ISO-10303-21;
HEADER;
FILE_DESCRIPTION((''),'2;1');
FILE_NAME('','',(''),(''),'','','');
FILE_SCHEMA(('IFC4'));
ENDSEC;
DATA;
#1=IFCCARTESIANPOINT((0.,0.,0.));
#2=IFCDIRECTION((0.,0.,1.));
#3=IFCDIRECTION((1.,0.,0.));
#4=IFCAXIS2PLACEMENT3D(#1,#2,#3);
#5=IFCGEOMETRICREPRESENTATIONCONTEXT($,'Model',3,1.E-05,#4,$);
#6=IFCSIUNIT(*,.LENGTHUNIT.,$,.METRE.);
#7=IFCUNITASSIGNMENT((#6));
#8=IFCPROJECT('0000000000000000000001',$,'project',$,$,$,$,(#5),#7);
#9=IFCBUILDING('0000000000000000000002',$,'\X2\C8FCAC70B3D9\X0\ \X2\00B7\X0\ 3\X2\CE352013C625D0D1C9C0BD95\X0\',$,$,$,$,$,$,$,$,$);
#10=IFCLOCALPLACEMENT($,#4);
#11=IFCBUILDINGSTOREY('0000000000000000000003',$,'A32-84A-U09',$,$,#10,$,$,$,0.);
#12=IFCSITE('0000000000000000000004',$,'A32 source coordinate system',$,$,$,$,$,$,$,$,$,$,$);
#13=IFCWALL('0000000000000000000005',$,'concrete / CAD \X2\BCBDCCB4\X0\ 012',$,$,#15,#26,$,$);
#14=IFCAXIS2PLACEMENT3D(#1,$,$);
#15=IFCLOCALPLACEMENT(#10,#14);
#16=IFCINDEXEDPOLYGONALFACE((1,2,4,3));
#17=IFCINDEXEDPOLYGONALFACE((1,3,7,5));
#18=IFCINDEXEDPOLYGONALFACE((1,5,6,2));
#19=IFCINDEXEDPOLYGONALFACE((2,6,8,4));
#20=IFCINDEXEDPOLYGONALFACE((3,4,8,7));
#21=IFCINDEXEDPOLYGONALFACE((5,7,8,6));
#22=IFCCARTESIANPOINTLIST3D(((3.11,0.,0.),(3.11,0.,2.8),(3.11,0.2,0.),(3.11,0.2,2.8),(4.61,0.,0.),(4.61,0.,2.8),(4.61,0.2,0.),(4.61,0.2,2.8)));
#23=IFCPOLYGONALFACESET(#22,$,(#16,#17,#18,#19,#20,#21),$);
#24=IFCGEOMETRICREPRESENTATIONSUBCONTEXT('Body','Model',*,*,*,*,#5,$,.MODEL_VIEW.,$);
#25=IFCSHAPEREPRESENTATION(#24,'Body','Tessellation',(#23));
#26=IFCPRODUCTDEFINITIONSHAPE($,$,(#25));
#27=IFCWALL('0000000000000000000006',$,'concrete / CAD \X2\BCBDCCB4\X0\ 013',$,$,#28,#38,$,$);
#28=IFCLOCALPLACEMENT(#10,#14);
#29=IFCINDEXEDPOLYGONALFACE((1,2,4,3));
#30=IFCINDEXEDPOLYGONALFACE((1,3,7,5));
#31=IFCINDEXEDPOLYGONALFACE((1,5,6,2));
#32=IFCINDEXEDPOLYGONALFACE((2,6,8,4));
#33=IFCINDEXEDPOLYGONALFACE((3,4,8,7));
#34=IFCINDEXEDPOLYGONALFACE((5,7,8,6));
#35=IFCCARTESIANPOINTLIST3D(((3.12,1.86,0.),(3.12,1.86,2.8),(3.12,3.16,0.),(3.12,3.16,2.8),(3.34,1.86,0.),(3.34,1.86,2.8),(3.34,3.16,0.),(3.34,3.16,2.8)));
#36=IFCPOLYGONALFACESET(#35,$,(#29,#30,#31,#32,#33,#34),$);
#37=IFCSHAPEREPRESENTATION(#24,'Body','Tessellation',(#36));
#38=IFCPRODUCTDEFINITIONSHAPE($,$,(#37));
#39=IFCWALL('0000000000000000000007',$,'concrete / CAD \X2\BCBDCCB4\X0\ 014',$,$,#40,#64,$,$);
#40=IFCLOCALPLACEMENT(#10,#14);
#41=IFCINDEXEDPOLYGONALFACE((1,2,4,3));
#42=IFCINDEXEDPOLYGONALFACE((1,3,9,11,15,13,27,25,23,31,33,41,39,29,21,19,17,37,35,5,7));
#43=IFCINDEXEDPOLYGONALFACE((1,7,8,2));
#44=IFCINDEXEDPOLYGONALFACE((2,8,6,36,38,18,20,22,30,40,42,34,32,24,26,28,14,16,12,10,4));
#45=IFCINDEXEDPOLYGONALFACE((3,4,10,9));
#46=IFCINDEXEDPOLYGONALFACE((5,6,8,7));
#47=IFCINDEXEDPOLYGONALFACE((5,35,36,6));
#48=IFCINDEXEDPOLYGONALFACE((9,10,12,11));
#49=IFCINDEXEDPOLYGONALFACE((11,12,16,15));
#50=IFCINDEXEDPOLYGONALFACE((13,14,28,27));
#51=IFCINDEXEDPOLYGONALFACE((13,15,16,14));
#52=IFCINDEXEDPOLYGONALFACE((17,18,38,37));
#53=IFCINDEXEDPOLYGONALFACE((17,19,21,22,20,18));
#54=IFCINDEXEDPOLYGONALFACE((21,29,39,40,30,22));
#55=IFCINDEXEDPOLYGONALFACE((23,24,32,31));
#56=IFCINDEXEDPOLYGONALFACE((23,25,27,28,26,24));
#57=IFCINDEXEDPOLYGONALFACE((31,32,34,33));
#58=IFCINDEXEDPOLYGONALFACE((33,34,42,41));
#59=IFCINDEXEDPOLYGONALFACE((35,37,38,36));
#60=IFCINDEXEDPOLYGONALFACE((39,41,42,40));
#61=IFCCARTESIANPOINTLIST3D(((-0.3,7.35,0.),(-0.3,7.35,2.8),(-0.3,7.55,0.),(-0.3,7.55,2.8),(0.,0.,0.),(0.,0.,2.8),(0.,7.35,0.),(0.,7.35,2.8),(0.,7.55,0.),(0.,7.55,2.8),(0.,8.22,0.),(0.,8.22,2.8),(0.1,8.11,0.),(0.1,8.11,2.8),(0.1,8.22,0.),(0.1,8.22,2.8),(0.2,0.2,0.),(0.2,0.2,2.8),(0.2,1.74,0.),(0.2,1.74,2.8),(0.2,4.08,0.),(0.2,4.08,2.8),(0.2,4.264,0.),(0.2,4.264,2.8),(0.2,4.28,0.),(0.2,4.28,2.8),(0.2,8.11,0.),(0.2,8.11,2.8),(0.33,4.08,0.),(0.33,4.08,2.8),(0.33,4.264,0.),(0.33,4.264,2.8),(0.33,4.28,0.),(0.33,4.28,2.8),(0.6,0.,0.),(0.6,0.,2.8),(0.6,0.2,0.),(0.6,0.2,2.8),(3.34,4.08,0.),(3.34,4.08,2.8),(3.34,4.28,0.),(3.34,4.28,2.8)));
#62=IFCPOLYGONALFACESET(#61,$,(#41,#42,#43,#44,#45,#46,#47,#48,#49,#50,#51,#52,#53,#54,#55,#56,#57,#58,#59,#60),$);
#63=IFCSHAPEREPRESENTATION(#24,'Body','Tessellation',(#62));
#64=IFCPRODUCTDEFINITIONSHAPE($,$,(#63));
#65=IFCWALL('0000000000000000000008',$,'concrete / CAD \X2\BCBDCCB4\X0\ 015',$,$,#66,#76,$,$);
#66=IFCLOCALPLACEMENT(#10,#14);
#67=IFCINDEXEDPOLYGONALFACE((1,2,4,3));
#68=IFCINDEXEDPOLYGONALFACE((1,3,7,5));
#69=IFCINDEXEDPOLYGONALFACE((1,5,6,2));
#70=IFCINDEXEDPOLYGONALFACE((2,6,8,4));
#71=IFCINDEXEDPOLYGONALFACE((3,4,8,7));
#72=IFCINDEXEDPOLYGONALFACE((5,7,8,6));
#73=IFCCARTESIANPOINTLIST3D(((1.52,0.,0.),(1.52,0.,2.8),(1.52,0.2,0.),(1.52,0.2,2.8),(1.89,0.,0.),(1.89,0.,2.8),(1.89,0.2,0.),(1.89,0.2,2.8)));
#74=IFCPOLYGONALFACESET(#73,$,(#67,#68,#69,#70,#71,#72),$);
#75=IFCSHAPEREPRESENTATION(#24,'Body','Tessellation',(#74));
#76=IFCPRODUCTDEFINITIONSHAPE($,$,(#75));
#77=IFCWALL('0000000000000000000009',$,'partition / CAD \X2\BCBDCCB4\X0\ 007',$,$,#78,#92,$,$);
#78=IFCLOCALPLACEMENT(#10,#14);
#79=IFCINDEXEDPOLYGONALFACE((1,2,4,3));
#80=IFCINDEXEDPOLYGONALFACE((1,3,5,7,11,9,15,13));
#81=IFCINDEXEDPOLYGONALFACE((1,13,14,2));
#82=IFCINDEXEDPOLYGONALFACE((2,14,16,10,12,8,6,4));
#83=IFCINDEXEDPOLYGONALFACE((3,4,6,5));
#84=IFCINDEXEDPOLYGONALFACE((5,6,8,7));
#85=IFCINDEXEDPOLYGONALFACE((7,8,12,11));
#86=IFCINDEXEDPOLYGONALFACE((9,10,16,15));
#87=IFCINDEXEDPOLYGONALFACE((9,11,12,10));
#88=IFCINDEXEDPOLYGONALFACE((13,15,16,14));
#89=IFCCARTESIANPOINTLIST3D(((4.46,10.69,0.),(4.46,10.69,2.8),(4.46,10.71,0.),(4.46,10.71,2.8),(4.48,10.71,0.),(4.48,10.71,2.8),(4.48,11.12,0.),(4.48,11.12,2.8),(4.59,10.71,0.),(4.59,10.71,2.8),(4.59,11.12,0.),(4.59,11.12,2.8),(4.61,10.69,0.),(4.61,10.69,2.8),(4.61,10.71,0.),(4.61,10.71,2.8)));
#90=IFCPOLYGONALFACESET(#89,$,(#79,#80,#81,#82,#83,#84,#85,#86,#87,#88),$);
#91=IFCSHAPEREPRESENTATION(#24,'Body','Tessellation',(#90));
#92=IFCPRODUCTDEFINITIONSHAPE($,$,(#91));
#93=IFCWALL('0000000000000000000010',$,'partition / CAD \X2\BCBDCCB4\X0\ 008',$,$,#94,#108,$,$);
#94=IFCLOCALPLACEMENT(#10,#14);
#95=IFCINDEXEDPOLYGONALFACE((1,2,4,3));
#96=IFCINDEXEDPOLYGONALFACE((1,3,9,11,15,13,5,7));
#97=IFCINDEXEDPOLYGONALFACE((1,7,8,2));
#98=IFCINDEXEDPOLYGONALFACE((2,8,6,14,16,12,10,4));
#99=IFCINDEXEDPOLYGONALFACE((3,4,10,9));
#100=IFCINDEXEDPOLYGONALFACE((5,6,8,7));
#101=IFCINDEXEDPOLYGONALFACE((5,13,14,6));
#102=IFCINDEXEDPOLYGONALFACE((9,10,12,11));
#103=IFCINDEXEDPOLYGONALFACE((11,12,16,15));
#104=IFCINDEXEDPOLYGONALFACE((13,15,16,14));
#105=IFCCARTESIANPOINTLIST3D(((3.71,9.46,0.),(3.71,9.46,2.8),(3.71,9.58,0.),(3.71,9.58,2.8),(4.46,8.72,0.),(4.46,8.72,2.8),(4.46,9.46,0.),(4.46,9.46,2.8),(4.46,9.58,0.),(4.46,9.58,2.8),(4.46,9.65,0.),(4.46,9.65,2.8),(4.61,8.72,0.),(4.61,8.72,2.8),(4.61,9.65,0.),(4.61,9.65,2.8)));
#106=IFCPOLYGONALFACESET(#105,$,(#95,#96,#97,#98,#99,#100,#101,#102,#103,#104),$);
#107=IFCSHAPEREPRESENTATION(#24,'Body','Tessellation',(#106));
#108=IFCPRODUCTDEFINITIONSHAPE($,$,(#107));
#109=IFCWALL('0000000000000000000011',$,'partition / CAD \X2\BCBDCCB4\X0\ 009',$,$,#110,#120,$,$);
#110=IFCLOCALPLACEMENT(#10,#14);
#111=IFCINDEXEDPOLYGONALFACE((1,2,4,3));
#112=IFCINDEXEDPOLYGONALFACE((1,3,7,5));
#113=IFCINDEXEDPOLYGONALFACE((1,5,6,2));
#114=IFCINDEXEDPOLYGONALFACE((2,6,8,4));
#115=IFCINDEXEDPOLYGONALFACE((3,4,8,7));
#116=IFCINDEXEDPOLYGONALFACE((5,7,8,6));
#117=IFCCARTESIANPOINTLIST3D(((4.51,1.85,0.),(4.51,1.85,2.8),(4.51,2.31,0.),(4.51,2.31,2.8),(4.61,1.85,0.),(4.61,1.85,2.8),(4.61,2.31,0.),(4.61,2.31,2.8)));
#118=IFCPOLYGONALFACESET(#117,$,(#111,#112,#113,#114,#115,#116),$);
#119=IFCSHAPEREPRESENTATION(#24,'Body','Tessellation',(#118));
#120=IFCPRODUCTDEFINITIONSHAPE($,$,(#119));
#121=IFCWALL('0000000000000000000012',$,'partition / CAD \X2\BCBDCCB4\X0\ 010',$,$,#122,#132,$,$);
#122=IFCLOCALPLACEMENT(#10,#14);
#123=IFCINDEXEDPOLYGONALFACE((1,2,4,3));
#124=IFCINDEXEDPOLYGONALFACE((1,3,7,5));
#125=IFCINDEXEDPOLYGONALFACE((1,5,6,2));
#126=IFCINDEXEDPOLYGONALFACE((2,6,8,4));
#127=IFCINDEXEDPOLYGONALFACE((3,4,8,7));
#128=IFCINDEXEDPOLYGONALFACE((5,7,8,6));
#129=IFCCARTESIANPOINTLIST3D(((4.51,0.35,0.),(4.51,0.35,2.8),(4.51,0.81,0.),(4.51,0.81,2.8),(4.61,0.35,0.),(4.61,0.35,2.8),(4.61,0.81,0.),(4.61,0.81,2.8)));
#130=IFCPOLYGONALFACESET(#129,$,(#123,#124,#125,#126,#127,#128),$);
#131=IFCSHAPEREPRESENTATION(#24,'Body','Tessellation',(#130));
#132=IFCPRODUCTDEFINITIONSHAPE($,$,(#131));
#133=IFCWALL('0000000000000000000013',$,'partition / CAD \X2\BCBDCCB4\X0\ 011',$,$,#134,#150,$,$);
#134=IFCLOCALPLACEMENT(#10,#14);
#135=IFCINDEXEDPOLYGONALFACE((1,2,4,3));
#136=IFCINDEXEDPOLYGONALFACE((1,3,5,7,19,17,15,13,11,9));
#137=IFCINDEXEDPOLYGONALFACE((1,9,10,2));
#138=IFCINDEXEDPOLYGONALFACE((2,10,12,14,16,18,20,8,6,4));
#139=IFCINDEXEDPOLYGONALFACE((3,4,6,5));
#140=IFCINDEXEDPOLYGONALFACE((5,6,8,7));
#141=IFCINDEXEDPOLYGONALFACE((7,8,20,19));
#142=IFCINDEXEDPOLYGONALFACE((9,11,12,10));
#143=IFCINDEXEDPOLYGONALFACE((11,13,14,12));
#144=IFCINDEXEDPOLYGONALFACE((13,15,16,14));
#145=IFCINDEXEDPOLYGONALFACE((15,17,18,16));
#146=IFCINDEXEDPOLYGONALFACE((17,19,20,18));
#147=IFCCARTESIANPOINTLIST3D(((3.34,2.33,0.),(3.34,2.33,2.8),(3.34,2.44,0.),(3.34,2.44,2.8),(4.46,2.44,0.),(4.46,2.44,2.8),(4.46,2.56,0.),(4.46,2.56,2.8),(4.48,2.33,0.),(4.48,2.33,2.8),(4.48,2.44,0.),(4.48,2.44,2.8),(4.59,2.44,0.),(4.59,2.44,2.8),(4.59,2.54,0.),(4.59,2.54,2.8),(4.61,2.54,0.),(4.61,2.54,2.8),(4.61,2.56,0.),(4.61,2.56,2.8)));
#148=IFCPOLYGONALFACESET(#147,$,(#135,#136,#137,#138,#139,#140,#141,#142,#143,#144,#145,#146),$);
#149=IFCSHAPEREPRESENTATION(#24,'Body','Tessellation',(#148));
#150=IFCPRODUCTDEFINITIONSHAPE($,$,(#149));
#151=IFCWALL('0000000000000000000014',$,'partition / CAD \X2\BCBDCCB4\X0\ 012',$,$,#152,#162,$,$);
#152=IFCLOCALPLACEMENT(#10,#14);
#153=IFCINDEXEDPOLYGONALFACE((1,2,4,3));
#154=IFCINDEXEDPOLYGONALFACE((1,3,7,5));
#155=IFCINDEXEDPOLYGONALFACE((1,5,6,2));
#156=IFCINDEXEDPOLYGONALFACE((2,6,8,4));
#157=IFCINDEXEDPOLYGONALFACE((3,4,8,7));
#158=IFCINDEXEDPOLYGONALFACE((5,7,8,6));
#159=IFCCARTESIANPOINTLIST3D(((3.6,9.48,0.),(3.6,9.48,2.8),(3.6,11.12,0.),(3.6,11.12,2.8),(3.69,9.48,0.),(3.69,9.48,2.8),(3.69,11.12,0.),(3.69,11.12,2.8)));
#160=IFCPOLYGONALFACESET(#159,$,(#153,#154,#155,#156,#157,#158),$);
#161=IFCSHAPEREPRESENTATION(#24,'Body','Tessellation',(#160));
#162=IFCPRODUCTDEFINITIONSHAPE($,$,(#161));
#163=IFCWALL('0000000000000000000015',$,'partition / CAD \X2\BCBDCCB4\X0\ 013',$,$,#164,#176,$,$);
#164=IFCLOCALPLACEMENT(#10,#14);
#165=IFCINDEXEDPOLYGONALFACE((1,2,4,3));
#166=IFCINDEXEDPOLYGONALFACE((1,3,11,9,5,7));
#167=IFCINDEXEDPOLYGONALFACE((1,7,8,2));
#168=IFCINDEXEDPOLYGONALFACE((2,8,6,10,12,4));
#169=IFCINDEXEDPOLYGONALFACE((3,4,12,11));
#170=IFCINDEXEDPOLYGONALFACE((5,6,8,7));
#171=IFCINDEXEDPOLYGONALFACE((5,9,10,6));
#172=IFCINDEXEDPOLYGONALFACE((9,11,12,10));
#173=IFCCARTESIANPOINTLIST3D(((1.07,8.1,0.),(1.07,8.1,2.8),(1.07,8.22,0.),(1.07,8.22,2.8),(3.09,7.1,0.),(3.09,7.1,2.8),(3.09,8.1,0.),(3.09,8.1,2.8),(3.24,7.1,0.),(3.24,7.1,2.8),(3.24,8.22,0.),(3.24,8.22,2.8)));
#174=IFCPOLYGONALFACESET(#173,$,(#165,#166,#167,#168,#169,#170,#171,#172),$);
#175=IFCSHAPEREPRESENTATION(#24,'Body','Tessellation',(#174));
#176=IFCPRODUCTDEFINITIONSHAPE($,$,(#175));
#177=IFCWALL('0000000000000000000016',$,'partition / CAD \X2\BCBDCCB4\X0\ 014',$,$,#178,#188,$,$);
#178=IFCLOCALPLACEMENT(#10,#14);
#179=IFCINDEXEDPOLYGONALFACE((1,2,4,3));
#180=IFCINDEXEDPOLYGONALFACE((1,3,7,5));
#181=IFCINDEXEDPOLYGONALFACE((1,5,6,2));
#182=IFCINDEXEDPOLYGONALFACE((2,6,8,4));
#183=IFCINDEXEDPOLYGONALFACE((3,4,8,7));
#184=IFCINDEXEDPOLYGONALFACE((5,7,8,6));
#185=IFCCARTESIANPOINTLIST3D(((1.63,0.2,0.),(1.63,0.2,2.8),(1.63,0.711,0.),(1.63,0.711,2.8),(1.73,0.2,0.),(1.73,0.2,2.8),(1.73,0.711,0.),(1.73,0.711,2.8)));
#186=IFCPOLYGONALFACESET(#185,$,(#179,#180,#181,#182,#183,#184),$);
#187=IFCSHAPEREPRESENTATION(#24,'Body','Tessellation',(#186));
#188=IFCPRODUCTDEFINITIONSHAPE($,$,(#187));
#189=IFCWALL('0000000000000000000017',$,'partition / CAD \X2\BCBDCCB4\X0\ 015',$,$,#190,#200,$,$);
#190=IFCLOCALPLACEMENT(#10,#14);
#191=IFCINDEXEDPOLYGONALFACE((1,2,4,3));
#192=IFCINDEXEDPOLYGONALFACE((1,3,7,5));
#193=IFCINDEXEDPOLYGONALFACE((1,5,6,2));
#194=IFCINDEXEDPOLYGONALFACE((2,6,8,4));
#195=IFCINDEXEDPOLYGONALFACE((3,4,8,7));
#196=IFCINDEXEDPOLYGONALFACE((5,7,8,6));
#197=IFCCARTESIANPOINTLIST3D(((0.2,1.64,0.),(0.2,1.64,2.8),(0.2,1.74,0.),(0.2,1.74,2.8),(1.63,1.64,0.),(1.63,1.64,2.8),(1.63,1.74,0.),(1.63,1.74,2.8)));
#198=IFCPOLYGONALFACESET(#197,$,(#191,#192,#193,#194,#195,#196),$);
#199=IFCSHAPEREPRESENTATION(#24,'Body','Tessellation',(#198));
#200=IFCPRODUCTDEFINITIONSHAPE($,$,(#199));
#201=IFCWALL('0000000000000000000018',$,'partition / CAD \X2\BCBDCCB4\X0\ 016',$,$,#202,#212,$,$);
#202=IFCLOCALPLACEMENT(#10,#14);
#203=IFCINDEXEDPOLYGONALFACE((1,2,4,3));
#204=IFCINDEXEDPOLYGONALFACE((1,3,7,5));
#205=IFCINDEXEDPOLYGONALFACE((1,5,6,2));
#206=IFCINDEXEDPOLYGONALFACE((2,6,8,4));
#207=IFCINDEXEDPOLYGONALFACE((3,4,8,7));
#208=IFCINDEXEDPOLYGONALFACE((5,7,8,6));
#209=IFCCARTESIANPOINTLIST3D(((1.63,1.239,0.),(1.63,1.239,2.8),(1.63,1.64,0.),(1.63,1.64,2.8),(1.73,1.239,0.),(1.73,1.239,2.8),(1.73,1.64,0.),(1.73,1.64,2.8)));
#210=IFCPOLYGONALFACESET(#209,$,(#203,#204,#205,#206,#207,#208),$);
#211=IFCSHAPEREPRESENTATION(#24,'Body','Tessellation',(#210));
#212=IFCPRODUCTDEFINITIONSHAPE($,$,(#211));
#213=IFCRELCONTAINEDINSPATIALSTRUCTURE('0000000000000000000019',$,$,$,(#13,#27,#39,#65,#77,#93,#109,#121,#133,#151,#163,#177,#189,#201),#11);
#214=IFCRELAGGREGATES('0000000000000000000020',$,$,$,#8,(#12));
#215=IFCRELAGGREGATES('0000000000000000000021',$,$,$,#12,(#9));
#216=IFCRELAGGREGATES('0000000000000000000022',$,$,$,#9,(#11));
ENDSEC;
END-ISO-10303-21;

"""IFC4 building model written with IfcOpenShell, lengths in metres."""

from ifc_helpers import new_model, si_unit, origin, origin_with_axes, place, context, subcontext, project, spatial, polyline, outline, extrude, element, save


model = new_model("IFC4")

# Units and contexts
model_context = context("Model", 3, precision=1e-05, world=origin_with_axes())
body_context = subcontext(model_context, "Body", "Model", "MODEL_VIEW")
ifc_project = project(units=[si_unit("LENGTHUNIT", "METRE")], contexts=[model_context])

# Site, building, storey
site = spatial("IfcSite", under=ifc_project, Name="A32 source coordinate system")
building = spatial("IfcBuilding", under=site, Name="주거동 · 3층–옥탑지붕")
storey_placement = place(None, origin_with_axes())
storey = spatial("IfcBuildingStorey", under=building, at=storey_placement, Name="A32-84A-U09", Elevation=0.0)

# Walls
wall_1_placement = place(storey_placement, origin_with_axes())
element("IfcWall", 1, at=wall_1_placement, inside=storey, Name="concrete / CAD 벽체 012", context=body_context, shape_type="SweptSolid", body=[
    extrude(outline(polyline([(3.11, 0.0), (3.11, 0.2), (4.61, 0.2), (4.61, 0.0), (3.11, 0.0)])), origin(), (0.0, 0.0, 1.0), 2.8),
])
wall_2_placement = place(storey_placement, origin_with_axes())
element("IfcWall", 2, at=wall_2_placement, inside=storey, Name="concrete / CAD 벽체 013", context=body_context, shape_type="SweptSolid", body=[
    extrude(outline(polyline([(3.12, 3.16), (3.34, 3.16), (3.34, 1.86), (3.12, 1.86), (3.12, 3.16)])), origin(), (0.0, 0.0, 1.0), 2.8),
])
wall_3_placement = place(storey_placement, origin_with_axes())
element("IfcWall", 3, at=wall_3_placement, inside=storey, Name="concrete / CAD 벽체 014", context=body_context, shape_type="SweptSolid", body=[
    extrude(outline(polyline([(3.34, 4.08), (0.33, 4.08), (0.2, 4.08), (0.2, 1.74), (0.2, 0.2), (0.6, 0.2), (0.6, 0.0), (0.0, 0.0), (0.0, 7.35), (-0.3, 7.35), (-0.3, 7.55), (0.0, 7.55), (0.0, 8.22), (0.1, 8.22), (0.1, 8.11), (0.2, 8.11), (0.2, 4.28), (0.2, 4.264), (0.33, 4.264), (0.33, 4.28), (3.34, 4.28), (3.34, 4.08)])), origin(), (0.0, 0.0, 1.0), 2.8),
])
wall_4_placement = place(storey_placement, origin_with_axes())
element("IfcWall", 4, at=wall_4_placement, inside=storey, Name="concrete / CAD 벽체 015", context=body_context, shape_type="SweptSolid", body=[
    extrude(outline(polyline([(1.52, 0.2), (1.89, 0.2), (1.89, 0.0), (1.52, 0.0), (1.52, 0.2)])), origin(), (0.0, 0.0, 1.0), 2.8),
])
wall_5_placement = place(storey_placement, origin_with_axes())
element("IfcWall", 5, at=wall_5_placement, inside=storey, Name="partition / CAD 벽체 007", context=body_context, shape_type="SweptSolid", body=[
    extrude(outline(polyline([(4.46, 10.71), (4.48, 10.71), (4.48, 11.12), (4.59, 11.12), (4.59, 10.71), (4.61, 10.71), (4.61, 10.69), (4.46, 10.69), (4.46, 10.71)])), origin(), (0.0, 0.0, 1.0), 2.8),
])
wall_6_placement = place(storey_placement, origin_with_axes())
element("IfcWall", 6, at=wall_6_placement, inside=storey, Name="partition / CAD 벽체 008", context=body_context, shape_type="SweptSolid", body=[
    extrude(outline(polyline([(4.61, 8.72), (4.46, 8.72), (4.46, 9.46), (3.71, 9.46), (3.71, 9.58), (4.46, 9.58), (4.46, 9.65), (4.61, 9.65), (4.61, 8.72)])), origin(), (0.0, 0.0, 1.0), 2.8),
])
wall_7_placement = place(storey_placement, origin_with_axes())
element("IfcWall", 7, at=wall_7_placement, inside=storey, Name="partition / CAD 벽체 009", context=body_context, shape_type="SweptSolid", body=[
    extrude(outline(polyline([(4.51, 1.85), (4.51, 2.31), (4.61, 2.31), (4.61, 1.85), (4.51, 1.85)])), origin(), (0.0, 0.0, 1.0), 2.8),
])
wall_8_placement = place(storey_placement, origin_with_axes())
element("IfcWall", 8, at=wall_8_placement, inside=storey, Name="partition / CAD 벽체 010", context=body_context, shape_type="SweptSolid", body=[
    extrude(outline(polyline([(4.51, 0.81), (4.61, 0.81), (4.61, 0.35), (4.51, 0.35), (4.51, 0.81)])), origin(), (0.0, 0.0, 1.0), 2.8),
])
wall_9_placement = place(storey_placement, origin_with_axes())
element("IfcWall", 9, at=wall_9_placement, inside=storey, Name="partition / CAD 벽체 011", context=body_context, shape_type="SweptSolid", body=[
    extrude(outline(polyline([(3.34, 2.33), (3.34, 2.44), (4.46, 2.44), (4.46, 2.56), (4.61, 2.56), (4.61, 2.54), (4.59, 2.54), (4.59, 2.44), (4.48, 2.44), (4.48, 2.33), (3.34, 2.33)])), origin(), (0.0, 0.0, 1.0), 2.8),
])
wall_10_placement = place(storey_placement, origin_with_axes())
element("IfcWall", 10, at=wall_10_placement, inside=storey, Name="partition / CAD 벽체 012", context=body_context, shape_type="SweptSolid", body=[
    extrude(outline(polyline([(3.6, 11.12), (3.69, 11.12), (3.69, 9.48), (3.6, 9.48), (3.6, 11.12)])), origin(), (0.0, 0.0, 1.0), 2.8),
])
wall_11_placement = place(storey_placement, origin_with_axes())
element("IfcWall", 11, at=wall_11_placement, inside=storey, Name="partition / CAD 벽체 013", context=body_context, shape_type="SweptSolid", body=[
    extrude(outline(polyline([(3.09, 8.1), (1.07, 8.1), (1.07, 8.22), (3.24, 8.22), (3.24, 7.1), (3.09, 7.1), (3.09, 8.1)])), origin(), (0.0, 0.0, 1.0), 2.8),
])
wall_12_placement = place(storey_placement, origin_with_axes())
element("IfcWall", 12, at=wall_12_placement, inside=storey, Name="partition / CAD 벽체 014", context=body_context, shape_type="SweptSolid", body=[
    extrude(outline(polyline([(1.73, 0.2), (1.63, 0.2), (1.63, 0.711), (1.73, 0.711), (1.73, 0.2)])), origin(), (0.0, 0.0, 1.0), 2.8),
])
wall_13_placement = place(storey_placement, origin_with_axes())
element("IfcWall", 13, at=wall_13_placement, inside=storey, Name="partition / CAD 벽체 015", context=body_context, shape_type="SweptSolid", body=[
    extrude(outline(polyline([(1.63, 1.74), (1.63, 1.64), (0.2, 1.64), (0.2, 1.74), (1.63, 1.74)])), origin(), (0.0, 0.0, 1.0), 2.8),
])
wall_14_placement = place(storey_placement, origin_with_axes())
element("IfcWall", 14, at=wall_14_placement, inside=storey, Name="partition / CAD 벽체 016", context=body_context, shape_type="SweptSolid", body=[
    extrude(outline(polyline([(1.73, 1.239), (1.63, 1.239), (1.63, 1.64), (1.73, 1.64), (1.73, 1.239)])), origin(), (0.0, 0.0, 1.0), 2.8),
])

save(model, "model.ifc")
